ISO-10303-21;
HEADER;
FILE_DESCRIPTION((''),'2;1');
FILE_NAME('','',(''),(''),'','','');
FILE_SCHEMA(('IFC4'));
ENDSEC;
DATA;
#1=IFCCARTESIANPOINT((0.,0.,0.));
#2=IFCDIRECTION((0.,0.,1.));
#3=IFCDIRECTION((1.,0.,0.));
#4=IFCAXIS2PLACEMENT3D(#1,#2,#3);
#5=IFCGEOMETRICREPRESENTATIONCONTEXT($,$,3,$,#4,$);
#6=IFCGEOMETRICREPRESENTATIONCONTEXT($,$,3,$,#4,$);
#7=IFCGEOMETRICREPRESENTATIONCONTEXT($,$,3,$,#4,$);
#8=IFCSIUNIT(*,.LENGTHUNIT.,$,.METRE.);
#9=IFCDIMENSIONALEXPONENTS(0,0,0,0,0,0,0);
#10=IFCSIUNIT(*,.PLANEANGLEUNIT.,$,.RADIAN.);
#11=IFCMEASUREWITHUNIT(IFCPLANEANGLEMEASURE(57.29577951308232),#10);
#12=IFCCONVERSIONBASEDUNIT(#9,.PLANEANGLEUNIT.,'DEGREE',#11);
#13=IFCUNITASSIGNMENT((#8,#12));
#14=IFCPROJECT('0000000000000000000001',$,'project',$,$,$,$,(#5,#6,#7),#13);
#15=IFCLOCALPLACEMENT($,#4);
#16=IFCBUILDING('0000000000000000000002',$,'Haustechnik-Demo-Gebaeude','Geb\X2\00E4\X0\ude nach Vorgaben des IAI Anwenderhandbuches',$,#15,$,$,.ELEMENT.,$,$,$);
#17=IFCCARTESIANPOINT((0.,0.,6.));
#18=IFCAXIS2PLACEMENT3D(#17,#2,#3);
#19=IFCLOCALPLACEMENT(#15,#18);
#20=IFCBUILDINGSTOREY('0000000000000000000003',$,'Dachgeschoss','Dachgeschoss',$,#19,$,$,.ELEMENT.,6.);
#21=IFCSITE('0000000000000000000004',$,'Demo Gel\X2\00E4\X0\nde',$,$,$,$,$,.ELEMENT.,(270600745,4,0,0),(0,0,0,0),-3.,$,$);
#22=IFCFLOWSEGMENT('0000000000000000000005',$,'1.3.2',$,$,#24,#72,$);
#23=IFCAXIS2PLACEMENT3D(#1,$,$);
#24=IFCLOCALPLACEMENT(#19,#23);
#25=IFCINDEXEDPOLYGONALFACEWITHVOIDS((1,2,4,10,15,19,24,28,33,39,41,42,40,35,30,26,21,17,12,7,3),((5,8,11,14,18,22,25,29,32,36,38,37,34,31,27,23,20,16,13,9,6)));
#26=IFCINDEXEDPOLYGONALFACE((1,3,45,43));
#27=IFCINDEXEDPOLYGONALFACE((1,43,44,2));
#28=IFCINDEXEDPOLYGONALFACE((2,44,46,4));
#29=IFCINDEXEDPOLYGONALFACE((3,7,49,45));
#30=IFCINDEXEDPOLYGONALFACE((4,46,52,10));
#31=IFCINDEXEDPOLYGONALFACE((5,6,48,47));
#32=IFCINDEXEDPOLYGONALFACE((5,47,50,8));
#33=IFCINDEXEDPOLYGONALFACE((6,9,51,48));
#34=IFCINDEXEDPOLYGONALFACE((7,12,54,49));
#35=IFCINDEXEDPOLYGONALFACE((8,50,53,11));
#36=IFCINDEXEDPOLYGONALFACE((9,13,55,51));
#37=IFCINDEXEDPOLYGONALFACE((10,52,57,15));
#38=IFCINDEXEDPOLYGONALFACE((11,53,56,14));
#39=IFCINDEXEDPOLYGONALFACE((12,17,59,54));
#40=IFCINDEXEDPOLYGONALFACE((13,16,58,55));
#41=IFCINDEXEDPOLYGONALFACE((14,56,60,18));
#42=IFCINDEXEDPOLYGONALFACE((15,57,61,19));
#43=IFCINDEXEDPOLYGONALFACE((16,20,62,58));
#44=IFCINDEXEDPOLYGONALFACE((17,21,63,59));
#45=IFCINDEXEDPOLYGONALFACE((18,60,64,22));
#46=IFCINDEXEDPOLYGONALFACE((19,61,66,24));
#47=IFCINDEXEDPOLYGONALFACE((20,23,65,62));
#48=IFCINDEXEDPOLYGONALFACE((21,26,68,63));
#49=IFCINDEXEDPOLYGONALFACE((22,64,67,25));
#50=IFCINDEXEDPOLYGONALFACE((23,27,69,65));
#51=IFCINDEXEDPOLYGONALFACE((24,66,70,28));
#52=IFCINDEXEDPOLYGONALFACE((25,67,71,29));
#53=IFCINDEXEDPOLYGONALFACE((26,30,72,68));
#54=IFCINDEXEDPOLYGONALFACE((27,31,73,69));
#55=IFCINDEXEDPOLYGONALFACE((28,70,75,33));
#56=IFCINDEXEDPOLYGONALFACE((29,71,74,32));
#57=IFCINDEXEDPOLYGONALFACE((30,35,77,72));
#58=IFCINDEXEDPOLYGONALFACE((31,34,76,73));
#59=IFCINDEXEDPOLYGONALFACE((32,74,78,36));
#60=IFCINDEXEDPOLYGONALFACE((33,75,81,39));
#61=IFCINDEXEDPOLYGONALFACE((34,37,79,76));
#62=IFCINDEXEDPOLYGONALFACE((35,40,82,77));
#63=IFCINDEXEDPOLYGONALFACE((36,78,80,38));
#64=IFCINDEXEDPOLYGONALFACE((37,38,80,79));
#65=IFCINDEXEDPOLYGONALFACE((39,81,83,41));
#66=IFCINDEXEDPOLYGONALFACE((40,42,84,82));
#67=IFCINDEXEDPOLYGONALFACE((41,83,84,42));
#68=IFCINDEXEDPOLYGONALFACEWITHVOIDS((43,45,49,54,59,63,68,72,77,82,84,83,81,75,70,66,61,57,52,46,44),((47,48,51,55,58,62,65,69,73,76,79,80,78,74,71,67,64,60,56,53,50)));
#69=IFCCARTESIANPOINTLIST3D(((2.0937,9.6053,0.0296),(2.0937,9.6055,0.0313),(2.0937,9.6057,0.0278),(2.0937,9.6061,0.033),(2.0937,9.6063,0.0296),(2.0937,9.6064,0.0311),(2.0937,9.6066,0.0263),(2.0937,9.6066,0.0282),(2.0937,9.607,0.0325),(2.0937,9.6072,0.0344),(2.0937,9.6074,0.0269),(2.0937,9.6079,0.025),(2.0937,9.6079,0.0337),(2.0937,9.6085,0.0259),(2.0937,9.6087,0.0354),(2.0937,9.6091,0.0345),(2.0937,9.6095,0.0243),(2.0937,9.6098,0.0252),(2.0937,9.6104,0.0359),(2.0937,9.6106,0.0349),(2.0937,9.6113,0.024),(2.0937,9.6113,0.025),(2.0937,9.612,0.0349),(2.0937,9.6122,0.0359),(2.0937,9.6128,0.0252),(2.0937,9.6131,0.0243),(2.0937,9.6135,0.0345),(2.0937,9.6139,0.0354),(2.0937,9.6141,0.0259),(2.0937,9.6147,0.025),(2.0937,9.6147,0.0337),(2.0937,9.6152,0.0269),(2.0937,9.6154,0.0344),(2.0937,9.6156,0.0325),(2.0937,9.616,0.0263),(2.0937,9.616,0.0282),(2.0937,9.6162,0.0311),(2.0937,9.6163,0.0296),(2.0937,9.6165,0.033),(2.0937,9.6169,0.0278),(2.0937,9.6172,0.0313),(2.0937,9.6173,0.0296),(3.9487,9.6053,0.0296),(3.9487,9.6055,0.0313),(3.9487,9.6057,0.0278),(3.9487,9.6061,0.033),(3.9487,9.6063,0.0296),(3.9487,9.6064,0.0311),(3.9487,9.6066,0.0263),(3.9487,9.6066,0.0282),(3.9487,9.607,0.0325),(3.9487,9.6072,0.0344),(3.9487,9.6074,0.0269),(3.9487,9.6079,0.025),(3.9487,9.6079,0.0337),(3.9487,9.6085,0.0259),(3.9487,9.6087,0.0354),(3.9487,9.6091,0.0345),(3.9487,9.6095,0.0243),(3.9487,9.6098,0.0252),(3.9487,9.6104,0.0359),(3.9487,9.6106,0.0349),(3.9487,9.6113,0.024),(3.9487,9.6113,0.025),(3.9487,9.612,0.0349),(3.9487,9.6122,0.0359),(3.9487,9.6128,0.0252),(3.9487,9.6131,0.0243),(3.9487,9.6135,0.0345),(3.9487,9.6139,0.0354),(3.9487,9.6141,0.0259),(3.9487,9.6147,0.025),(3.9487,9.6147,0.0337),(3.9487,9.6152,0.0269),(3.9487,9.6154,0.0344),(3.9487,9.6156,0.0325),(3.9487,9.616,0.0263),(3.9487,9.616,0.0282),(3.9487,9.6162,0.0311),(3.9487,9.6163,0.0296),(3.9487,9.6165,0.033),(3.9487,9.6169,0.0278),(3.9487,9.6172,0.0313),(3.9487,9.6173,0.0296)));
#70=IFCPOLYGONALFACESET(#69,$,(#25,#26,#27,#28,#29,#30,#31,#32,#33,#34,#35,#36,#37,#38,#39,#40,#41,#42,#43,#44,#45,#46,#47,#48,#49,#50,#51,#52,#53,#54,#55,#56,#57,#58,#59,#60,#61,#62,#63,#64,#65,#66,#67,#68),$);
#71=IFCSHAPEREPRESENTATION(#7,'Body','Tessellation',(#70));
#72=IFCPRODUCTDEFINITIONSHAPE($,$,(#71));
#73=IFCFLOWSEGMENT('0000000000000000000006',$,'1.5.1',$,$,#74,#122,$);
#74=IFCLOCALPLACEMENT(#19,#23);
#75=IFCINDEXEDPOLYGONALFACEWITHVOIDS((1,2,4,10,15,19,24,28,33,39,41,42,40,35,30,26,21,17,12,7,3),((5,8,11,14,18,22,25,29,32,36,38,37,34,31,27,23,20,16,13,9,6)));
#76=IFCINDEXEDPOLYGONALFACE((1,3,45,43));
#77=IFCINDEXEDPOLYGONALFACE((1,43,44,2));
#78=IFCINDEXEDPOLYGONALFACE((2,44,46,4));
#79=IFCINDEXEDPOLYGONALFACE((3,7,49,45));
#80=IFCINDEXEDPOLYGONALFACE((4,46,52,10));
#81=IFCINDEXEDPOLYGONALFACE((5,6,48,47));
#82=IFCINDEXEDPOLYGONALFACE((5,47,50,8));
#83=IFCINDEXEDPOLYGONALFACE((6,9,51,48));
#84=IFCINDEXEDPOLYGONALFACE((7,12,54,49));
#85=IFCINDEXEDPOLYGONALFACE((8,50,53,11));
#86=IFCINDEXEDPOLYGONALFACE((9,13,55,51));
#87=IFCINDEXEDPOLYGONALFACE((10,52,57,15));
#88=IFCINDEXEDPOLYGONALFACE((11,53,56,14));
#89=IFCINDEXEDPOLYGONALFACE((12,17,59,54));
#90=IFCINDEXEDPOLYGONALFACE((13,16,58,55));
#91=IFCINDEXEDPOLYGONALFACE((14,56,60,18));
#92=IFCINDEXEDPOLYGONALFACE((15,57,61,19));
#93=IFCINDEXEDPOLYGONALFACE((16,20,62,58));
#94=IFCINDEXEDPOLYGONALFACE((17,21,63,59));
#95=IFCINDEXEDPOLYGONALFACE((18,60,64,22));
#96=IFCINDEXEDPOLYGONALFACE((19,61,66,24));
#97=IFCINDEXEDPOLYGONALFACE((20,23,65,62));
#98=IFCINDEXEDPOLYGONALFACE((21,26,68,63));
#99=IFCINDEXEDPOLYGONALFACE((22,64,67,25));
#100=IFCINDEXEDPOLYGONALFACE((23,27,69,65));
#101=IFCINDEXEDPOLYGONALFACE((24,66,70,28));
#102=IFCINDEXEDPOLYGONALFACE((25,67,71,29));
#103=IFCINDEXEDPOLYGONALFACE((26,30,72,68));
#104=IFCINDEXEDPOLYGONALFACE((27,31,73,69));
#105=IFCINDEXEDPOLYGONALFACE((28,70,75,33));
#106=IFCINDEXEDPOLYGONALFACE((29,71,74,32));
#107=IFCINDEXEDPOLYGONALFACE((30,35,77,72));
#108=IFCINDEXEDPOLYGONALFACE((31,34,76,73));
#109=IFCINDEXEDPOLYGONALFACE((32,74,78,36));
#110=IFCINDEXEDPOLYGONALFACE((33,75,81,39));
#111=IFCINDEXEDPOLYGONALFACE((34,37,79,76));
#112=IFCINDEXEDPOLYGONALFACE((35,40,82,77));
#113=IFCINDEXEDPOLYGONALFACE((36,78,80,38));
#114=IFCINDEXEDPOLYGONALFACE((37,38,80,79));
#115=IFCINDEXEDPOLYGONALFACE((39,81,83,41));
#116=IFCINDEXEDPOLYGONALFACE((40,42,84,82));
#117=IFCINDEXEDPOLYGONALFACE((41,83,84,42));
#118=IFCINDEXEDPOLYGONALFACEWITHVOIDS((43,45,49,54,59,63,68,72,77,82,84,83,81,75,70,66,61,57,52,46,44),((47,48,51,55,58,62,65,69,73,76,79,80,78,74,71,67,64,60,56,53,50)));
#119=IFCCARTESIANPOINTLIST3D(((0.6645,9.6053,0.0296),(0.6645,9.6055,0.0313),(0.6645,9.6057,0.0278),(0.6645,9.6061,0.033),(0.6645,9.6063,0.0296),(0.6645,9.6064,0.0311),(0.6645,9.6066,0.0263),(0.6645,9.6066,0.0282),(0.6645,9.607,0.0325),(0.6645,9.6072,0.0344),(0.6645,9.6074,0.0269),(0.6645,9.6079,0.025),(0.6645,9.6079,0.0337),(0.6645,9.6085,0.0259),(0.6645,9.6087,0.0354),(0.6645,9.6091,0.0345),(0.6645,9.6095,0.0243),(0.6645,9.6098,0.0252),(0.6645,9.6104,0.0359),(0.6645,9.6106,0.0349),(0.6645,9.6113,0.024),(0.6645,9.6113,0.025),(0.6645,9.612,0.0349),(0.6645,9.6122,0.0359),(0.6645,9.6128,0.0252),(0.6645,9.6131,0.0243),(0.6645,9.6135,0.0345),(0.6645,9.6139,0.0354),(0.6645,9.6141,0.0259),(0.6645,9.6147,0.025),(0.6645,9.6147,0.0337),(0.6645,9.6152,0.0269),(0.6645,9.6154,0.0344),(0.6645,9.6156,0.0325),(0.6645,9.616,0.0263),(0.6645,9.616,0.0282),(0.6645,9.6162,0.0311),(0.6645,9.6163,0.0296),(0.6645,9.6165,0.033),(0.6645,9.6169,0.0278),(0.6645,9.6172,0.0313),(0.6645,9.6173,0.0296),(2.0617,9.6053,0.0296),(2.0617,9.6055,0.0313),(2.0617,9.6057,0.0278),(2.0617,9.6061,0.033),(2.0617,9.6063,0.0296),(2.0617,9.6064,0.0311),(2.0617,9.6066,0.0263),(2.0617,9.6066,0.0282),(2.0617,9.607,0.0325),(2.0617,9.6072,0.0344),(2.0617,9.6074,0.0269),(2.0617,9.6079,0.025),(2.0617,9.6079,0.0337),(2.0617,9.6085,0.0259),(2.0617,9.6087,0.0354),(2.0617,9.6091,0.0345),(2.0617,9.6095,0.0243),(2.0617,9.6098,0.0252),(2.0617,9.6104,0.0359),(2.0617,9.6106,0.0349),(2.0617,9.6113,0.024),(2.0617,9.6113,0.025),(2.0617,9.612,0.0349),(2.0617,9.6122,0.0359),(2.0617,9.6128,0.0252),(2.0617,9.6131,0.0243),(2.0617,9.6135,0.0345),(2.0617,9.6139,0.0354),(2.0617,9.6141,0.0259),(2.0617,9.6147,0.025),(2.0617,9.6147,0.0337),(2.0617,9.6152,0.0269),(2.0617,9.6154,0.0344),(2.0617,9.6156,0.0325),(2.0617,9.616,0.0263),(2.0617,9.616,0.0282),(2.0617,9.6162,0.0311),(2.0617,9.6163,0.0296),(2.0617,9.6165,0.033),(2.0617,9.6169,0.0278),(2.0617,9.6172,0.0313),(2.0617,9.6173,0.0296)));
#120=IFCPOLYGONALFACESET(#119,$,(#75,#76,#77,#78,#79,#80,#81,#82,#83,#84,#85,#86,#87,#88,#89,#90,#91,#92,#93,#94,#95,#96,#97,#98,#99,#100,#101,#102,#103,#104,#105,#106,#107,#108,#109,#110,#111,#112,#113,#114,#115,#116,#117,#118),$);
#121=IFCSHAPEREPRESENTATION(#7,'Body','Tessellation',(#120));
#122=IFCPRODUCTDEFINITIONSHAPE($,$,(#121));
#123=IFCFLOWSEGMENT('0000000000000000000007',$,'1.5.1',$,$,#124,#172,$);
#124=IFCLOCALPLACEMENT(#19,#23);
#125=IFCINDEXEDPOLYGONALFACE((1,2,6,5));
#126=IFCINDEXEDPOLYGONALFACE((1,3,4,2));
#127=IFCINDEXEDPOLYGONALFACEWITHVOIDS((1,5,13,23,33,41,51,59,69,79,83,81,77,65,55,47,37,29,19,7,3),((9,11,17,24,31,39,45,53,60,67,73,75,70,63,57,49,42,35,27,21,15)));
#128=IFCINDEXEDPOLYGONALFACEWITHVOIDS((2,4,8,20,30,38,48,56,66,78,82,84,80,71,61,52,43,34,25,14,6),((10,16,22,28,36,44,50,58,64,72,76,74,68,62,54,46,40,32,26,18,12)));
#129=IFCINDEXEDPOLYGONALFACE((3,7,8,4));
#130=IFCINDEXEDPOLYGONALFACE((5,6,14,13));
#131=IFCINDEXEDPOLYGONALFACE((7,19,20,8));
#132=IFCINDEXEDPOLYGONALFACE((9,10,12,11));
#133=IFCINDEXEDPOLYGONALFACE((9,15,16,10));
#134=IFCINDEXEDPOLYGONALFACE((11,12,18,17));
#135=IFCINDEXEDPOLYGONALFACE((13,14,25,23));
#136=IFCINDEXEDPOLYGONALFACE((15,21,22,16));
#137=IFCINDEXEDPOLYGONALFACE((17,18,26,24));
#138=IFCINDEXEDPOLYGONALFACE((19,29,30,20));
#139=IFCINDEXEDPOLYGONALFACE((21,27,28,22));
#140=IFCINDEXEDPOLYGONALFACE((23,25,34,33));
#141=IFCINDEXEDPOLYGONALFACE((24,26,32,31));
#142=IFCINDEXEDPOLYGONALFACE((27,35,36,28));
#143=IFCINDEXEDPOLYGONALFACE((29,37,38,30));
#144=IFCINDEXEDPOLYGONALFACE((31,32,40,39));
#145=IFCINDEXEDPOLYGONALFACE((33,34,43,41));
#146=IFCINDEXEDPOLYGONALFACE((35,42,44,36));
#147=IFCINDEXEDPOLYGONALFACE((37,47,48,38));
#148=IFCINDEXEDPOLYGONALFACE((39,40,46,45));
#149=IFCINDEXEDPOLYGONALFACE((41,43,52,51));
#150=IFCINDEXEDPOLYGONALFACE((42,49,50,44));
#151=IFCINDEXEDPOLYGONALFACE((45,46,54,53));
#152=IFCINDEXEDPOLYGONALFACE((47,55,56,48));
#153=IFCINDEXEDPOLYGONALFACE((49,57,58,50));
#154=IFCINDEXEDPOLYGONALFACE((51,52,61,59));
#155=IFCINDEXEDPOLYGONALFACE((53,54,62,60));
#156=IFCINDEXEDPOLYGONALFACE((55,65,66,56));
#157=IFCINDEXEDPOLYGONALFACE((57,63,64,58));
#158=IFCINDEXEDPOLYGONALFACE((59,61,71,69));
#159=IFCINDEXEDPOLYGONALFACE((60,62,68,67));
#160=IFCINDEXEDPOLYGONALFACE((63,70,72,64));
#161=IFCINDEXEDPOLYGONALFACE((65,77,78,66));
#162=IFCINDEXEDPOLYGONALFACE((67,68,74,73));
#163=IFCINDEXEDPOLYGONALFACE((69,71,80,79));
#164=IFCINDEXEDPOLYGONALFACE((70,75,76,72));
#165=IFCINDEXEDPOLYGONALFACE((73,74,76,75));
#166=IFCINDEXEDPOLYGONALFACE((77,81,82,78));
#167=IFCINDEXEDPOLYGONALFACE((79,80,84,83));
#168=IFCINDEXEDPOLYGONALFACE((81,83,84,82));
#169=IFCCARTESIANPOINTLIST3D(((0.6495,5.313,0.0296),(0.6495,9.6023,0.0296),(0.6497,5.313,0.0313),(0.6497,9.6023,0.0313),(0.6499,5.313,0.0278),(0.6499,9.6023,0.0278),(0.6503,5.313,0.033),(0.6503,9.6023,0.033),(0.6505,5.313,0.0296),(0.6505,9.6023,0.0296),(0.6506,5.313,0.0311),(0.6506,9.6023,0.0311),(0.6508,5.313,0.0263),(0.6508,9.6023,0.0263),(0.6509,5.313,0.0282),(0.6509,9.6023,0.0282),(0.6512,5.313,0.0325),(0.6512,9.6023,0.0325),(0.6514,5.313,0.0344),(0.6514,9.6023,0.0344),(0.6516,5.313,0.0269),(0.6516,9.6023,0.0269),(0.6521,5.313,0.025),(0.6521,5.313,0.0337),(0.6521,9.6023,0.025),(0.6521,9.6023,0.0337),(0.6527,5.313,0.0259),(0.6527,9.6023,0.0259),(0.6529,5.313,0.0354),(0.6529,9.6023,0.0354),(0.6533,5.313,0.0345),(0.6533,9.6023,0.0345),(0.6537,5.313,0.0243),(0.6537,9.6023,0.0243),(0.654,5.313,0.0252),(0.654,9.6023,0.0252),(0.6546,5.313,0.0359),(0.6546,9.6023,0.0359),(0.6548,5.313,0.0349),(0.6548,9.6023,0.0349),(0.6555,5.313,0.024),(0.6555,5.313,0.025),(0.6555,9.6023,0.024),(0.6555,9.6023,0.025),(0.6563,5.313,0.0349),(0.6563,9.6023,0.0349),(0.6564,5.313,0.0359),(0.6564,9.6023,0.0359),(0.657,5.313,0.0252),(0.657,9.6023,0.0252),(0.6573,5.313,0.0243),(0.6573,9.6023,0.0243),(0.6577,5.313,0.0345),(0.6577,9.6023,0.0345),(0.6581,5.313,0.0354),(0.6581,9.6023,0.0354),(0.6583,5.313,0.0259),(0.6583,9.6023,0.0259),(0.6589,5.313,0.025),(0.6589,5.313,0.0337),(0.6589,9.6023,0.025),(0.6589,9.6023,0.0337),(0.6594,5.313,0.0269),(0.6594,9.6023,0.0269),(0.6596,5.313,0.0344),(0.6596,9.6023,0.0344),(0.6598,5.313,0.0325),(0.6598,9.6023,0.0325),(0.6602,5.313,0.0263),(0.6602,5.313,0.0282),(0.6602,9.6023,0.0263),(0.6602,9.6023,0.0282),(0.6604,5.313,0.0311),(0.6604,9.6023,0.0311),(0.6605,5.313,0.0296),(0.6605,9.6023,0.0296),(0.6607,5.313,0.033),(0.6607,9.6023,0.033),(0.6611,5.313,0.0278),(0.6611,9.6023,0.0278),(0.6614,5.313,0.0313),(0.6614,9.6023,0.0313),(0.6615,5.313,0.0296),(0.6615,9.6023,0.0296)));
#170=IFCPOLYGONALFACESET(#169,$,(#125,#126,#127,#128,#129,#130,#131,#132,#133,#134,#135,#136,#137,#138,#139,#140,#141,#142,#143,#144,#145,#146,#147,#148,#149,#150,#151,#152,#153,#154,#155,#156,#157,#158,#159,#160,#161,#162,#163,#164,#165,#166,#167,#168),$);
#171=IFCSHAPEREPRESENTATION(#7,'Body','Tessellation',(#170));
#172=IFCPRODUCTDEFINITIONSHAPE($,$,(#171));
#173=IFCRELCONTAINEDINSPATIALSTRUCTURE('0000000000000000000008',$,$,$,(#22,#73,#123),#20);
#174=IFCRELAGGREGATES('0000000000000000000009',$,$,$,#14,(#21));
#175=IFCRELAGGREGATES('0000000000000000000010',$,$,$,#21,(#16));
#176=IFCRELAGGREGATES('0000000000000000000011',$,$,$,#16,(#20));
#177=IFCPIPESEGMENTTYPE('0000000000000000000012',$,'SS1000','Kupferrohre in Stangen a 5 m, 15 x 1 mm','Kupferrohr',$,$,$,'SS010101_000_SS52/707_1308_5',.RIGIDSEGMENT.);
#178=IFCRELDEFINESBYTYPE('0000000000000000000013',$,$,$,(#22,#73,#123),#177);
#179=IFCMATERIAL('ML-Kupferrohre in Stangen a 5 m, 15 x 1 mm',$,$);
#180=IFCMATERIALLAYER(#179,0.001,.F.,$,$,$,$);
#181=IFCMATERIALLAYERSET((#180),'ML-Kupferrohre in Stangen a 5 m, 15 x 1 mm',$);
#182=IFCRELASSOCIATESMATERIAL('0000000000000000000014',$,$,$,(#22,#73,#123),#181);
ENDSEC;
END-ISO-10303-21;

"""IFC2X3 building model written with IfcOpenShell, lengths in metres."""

from ifc_helpers import new_model, entity, si_unit, converted_unit, frame, origin_with_axes, origin_2d_with_axis, place, context, project, spatial, hollow_circle, extrude, material, layer, layer_set, layer_usage, type_object, element, save


model = new_model("IFC2X3")

# Units and contexts
context_of_model_1 = context(None, 3, world=origin_with_axes())
context_of_model_2 = context(None, 3, world=origin_with_axes())
context_of_model_3 = context(None, 3, world=origin_with_axes())
ifc_project = project(units=[si_unit("LENGTHUNIT", "METRE"), converted_unit("PLANEANGLEUNIT", "DEGREE", entity("IfcPlaneAngleMeasure", 57.29577951308232), si_unit("PLANEANGLEUNIT", "RADIAN"), dimensions=[0, 0, 0, 0, 0, 0, 0])], contexts=[context_of_model_1, context_of_model_2, context_of_model_3])

# Site, building, storey
site = spatial("IfcSite", under=ifc_project, Name="Demo Gelände", CompositionType="ELEMENT", RefLatitude=(270600745, 4, 0, 0), RefLongitude=(0, 0, 0, 0), RefElevation=-3.0)
building_placement = place(None, origin_with_axes())
building = spatial("IfcBuilding", under=site, at=building_placement, Name="Haustechnik-Demo-Gebaeude", Description="Gebäude nach Vorgaben des IAI Anwenderhandbuches", CompositionType="ELEMENT")
storey_placement = place(building_placement, frame((0.0, 0.0, 6.0), z_axis=(0.0, 0.0, 1.0), x_axis=(1.0, 0.0, 0.0)))
storey = spatial("IfcBuildingStorey", under=building, at=storey_placement, Name="Dachgeschoss", Description="Dachgeschoss", CompositionType="ELEMENT", Elevation=6.0)

# Flow segments
ifc_material = material(Name="ML-Kupferrohre in Stangen a 5 m, 15 x 1 mm")
ifc_layer = layer(ifc_material, 0.001, ventilated=False)
ifc_layer_set = layer_set([ifc_layer], Name="ML-Kupferrohre in Stangen a 5 m, 15 x 1 mm")
ifc_layer_usage = layer_usage(ifc_layer_set, "AXIS2", "POSITIVE", 0.0)
pipe_segment_type_1 = type_object("IfcPipeSegmentType", Name="SS1000", Description="Kupferrohre in Stangen a 5 m, 15 x 1 mm", ApplicableOccurrence="Kupferrohr", ElementType="SS010101_000_SS52/707_1308_5", PredefinedType="RIGIDSEGMENT")
flow_segment_1_placement = place(storey_placement, frame((3.9487, 9.6113, 0.03), z_axis=(-1.0, 0.0, 0.0), x_axis=(0.0, 0.0, -1.0)))
element("IfcFlowSegment", 1, at=flow_segment_1_placement, inside=storey, type_object=pipe_segment_type_1, material=ifc_layer_usage, Name="1.3.2", context=context_of_model_3, shape_type="SweptSolid", body=[
    extrude(hollow_circle(Radius=0.006, WallThickness=0.001, at=origin_2d_with_axis()), origin_with_axes(), (0.0, 0.0, 1.0), 1.855),
])
flow_segment_2_placement = place(storey_placement, frame((2.0617, 9.6113, 0.03), z_axis=(-1.0, 0.0, 0.0), x_axis=(0.0, 0.0, -1.0)))
element("IfcFlowSegment", 2, at=flow_segment_2_placement, inside=storey, type_object=pipe_segment_type_1, material=ifc_layer_usage, Name="1.5.1", context=context_of_model_3, shape_type="SweptSolid", body=[
    extrude(hollow_circle(Radius=0.006, WallThickness=0.001, at=origin_2d_with_axis()), origin_with_axes(), (0.0, 0.0, 1.0), 1.3972),
])
flow_segment_3_placement = place(storey_placement, frame((0.6555, 9.6023, 0.03), z_axis=(0.0, -1.0, 0.0), x_axis=(0.0, 0.0, -1.0)))
element("IfcFlowSegment", 3, at=flow_segment_3_placement, inside=storey, type_object=pipe_segment_type_1, material=ifc_layer_usage, Name="1.5.1", context=context_of_model_3, shape_type="SweptSolid", body=[
    extrude(hollow_circle(Radius=0.006, WallThickness=0.001, at=origin_2d_with_axis()), origin_with_axes(), (0.0, 0.0, 1.0), 4.2893),
])

save(model, "model.ifc")
